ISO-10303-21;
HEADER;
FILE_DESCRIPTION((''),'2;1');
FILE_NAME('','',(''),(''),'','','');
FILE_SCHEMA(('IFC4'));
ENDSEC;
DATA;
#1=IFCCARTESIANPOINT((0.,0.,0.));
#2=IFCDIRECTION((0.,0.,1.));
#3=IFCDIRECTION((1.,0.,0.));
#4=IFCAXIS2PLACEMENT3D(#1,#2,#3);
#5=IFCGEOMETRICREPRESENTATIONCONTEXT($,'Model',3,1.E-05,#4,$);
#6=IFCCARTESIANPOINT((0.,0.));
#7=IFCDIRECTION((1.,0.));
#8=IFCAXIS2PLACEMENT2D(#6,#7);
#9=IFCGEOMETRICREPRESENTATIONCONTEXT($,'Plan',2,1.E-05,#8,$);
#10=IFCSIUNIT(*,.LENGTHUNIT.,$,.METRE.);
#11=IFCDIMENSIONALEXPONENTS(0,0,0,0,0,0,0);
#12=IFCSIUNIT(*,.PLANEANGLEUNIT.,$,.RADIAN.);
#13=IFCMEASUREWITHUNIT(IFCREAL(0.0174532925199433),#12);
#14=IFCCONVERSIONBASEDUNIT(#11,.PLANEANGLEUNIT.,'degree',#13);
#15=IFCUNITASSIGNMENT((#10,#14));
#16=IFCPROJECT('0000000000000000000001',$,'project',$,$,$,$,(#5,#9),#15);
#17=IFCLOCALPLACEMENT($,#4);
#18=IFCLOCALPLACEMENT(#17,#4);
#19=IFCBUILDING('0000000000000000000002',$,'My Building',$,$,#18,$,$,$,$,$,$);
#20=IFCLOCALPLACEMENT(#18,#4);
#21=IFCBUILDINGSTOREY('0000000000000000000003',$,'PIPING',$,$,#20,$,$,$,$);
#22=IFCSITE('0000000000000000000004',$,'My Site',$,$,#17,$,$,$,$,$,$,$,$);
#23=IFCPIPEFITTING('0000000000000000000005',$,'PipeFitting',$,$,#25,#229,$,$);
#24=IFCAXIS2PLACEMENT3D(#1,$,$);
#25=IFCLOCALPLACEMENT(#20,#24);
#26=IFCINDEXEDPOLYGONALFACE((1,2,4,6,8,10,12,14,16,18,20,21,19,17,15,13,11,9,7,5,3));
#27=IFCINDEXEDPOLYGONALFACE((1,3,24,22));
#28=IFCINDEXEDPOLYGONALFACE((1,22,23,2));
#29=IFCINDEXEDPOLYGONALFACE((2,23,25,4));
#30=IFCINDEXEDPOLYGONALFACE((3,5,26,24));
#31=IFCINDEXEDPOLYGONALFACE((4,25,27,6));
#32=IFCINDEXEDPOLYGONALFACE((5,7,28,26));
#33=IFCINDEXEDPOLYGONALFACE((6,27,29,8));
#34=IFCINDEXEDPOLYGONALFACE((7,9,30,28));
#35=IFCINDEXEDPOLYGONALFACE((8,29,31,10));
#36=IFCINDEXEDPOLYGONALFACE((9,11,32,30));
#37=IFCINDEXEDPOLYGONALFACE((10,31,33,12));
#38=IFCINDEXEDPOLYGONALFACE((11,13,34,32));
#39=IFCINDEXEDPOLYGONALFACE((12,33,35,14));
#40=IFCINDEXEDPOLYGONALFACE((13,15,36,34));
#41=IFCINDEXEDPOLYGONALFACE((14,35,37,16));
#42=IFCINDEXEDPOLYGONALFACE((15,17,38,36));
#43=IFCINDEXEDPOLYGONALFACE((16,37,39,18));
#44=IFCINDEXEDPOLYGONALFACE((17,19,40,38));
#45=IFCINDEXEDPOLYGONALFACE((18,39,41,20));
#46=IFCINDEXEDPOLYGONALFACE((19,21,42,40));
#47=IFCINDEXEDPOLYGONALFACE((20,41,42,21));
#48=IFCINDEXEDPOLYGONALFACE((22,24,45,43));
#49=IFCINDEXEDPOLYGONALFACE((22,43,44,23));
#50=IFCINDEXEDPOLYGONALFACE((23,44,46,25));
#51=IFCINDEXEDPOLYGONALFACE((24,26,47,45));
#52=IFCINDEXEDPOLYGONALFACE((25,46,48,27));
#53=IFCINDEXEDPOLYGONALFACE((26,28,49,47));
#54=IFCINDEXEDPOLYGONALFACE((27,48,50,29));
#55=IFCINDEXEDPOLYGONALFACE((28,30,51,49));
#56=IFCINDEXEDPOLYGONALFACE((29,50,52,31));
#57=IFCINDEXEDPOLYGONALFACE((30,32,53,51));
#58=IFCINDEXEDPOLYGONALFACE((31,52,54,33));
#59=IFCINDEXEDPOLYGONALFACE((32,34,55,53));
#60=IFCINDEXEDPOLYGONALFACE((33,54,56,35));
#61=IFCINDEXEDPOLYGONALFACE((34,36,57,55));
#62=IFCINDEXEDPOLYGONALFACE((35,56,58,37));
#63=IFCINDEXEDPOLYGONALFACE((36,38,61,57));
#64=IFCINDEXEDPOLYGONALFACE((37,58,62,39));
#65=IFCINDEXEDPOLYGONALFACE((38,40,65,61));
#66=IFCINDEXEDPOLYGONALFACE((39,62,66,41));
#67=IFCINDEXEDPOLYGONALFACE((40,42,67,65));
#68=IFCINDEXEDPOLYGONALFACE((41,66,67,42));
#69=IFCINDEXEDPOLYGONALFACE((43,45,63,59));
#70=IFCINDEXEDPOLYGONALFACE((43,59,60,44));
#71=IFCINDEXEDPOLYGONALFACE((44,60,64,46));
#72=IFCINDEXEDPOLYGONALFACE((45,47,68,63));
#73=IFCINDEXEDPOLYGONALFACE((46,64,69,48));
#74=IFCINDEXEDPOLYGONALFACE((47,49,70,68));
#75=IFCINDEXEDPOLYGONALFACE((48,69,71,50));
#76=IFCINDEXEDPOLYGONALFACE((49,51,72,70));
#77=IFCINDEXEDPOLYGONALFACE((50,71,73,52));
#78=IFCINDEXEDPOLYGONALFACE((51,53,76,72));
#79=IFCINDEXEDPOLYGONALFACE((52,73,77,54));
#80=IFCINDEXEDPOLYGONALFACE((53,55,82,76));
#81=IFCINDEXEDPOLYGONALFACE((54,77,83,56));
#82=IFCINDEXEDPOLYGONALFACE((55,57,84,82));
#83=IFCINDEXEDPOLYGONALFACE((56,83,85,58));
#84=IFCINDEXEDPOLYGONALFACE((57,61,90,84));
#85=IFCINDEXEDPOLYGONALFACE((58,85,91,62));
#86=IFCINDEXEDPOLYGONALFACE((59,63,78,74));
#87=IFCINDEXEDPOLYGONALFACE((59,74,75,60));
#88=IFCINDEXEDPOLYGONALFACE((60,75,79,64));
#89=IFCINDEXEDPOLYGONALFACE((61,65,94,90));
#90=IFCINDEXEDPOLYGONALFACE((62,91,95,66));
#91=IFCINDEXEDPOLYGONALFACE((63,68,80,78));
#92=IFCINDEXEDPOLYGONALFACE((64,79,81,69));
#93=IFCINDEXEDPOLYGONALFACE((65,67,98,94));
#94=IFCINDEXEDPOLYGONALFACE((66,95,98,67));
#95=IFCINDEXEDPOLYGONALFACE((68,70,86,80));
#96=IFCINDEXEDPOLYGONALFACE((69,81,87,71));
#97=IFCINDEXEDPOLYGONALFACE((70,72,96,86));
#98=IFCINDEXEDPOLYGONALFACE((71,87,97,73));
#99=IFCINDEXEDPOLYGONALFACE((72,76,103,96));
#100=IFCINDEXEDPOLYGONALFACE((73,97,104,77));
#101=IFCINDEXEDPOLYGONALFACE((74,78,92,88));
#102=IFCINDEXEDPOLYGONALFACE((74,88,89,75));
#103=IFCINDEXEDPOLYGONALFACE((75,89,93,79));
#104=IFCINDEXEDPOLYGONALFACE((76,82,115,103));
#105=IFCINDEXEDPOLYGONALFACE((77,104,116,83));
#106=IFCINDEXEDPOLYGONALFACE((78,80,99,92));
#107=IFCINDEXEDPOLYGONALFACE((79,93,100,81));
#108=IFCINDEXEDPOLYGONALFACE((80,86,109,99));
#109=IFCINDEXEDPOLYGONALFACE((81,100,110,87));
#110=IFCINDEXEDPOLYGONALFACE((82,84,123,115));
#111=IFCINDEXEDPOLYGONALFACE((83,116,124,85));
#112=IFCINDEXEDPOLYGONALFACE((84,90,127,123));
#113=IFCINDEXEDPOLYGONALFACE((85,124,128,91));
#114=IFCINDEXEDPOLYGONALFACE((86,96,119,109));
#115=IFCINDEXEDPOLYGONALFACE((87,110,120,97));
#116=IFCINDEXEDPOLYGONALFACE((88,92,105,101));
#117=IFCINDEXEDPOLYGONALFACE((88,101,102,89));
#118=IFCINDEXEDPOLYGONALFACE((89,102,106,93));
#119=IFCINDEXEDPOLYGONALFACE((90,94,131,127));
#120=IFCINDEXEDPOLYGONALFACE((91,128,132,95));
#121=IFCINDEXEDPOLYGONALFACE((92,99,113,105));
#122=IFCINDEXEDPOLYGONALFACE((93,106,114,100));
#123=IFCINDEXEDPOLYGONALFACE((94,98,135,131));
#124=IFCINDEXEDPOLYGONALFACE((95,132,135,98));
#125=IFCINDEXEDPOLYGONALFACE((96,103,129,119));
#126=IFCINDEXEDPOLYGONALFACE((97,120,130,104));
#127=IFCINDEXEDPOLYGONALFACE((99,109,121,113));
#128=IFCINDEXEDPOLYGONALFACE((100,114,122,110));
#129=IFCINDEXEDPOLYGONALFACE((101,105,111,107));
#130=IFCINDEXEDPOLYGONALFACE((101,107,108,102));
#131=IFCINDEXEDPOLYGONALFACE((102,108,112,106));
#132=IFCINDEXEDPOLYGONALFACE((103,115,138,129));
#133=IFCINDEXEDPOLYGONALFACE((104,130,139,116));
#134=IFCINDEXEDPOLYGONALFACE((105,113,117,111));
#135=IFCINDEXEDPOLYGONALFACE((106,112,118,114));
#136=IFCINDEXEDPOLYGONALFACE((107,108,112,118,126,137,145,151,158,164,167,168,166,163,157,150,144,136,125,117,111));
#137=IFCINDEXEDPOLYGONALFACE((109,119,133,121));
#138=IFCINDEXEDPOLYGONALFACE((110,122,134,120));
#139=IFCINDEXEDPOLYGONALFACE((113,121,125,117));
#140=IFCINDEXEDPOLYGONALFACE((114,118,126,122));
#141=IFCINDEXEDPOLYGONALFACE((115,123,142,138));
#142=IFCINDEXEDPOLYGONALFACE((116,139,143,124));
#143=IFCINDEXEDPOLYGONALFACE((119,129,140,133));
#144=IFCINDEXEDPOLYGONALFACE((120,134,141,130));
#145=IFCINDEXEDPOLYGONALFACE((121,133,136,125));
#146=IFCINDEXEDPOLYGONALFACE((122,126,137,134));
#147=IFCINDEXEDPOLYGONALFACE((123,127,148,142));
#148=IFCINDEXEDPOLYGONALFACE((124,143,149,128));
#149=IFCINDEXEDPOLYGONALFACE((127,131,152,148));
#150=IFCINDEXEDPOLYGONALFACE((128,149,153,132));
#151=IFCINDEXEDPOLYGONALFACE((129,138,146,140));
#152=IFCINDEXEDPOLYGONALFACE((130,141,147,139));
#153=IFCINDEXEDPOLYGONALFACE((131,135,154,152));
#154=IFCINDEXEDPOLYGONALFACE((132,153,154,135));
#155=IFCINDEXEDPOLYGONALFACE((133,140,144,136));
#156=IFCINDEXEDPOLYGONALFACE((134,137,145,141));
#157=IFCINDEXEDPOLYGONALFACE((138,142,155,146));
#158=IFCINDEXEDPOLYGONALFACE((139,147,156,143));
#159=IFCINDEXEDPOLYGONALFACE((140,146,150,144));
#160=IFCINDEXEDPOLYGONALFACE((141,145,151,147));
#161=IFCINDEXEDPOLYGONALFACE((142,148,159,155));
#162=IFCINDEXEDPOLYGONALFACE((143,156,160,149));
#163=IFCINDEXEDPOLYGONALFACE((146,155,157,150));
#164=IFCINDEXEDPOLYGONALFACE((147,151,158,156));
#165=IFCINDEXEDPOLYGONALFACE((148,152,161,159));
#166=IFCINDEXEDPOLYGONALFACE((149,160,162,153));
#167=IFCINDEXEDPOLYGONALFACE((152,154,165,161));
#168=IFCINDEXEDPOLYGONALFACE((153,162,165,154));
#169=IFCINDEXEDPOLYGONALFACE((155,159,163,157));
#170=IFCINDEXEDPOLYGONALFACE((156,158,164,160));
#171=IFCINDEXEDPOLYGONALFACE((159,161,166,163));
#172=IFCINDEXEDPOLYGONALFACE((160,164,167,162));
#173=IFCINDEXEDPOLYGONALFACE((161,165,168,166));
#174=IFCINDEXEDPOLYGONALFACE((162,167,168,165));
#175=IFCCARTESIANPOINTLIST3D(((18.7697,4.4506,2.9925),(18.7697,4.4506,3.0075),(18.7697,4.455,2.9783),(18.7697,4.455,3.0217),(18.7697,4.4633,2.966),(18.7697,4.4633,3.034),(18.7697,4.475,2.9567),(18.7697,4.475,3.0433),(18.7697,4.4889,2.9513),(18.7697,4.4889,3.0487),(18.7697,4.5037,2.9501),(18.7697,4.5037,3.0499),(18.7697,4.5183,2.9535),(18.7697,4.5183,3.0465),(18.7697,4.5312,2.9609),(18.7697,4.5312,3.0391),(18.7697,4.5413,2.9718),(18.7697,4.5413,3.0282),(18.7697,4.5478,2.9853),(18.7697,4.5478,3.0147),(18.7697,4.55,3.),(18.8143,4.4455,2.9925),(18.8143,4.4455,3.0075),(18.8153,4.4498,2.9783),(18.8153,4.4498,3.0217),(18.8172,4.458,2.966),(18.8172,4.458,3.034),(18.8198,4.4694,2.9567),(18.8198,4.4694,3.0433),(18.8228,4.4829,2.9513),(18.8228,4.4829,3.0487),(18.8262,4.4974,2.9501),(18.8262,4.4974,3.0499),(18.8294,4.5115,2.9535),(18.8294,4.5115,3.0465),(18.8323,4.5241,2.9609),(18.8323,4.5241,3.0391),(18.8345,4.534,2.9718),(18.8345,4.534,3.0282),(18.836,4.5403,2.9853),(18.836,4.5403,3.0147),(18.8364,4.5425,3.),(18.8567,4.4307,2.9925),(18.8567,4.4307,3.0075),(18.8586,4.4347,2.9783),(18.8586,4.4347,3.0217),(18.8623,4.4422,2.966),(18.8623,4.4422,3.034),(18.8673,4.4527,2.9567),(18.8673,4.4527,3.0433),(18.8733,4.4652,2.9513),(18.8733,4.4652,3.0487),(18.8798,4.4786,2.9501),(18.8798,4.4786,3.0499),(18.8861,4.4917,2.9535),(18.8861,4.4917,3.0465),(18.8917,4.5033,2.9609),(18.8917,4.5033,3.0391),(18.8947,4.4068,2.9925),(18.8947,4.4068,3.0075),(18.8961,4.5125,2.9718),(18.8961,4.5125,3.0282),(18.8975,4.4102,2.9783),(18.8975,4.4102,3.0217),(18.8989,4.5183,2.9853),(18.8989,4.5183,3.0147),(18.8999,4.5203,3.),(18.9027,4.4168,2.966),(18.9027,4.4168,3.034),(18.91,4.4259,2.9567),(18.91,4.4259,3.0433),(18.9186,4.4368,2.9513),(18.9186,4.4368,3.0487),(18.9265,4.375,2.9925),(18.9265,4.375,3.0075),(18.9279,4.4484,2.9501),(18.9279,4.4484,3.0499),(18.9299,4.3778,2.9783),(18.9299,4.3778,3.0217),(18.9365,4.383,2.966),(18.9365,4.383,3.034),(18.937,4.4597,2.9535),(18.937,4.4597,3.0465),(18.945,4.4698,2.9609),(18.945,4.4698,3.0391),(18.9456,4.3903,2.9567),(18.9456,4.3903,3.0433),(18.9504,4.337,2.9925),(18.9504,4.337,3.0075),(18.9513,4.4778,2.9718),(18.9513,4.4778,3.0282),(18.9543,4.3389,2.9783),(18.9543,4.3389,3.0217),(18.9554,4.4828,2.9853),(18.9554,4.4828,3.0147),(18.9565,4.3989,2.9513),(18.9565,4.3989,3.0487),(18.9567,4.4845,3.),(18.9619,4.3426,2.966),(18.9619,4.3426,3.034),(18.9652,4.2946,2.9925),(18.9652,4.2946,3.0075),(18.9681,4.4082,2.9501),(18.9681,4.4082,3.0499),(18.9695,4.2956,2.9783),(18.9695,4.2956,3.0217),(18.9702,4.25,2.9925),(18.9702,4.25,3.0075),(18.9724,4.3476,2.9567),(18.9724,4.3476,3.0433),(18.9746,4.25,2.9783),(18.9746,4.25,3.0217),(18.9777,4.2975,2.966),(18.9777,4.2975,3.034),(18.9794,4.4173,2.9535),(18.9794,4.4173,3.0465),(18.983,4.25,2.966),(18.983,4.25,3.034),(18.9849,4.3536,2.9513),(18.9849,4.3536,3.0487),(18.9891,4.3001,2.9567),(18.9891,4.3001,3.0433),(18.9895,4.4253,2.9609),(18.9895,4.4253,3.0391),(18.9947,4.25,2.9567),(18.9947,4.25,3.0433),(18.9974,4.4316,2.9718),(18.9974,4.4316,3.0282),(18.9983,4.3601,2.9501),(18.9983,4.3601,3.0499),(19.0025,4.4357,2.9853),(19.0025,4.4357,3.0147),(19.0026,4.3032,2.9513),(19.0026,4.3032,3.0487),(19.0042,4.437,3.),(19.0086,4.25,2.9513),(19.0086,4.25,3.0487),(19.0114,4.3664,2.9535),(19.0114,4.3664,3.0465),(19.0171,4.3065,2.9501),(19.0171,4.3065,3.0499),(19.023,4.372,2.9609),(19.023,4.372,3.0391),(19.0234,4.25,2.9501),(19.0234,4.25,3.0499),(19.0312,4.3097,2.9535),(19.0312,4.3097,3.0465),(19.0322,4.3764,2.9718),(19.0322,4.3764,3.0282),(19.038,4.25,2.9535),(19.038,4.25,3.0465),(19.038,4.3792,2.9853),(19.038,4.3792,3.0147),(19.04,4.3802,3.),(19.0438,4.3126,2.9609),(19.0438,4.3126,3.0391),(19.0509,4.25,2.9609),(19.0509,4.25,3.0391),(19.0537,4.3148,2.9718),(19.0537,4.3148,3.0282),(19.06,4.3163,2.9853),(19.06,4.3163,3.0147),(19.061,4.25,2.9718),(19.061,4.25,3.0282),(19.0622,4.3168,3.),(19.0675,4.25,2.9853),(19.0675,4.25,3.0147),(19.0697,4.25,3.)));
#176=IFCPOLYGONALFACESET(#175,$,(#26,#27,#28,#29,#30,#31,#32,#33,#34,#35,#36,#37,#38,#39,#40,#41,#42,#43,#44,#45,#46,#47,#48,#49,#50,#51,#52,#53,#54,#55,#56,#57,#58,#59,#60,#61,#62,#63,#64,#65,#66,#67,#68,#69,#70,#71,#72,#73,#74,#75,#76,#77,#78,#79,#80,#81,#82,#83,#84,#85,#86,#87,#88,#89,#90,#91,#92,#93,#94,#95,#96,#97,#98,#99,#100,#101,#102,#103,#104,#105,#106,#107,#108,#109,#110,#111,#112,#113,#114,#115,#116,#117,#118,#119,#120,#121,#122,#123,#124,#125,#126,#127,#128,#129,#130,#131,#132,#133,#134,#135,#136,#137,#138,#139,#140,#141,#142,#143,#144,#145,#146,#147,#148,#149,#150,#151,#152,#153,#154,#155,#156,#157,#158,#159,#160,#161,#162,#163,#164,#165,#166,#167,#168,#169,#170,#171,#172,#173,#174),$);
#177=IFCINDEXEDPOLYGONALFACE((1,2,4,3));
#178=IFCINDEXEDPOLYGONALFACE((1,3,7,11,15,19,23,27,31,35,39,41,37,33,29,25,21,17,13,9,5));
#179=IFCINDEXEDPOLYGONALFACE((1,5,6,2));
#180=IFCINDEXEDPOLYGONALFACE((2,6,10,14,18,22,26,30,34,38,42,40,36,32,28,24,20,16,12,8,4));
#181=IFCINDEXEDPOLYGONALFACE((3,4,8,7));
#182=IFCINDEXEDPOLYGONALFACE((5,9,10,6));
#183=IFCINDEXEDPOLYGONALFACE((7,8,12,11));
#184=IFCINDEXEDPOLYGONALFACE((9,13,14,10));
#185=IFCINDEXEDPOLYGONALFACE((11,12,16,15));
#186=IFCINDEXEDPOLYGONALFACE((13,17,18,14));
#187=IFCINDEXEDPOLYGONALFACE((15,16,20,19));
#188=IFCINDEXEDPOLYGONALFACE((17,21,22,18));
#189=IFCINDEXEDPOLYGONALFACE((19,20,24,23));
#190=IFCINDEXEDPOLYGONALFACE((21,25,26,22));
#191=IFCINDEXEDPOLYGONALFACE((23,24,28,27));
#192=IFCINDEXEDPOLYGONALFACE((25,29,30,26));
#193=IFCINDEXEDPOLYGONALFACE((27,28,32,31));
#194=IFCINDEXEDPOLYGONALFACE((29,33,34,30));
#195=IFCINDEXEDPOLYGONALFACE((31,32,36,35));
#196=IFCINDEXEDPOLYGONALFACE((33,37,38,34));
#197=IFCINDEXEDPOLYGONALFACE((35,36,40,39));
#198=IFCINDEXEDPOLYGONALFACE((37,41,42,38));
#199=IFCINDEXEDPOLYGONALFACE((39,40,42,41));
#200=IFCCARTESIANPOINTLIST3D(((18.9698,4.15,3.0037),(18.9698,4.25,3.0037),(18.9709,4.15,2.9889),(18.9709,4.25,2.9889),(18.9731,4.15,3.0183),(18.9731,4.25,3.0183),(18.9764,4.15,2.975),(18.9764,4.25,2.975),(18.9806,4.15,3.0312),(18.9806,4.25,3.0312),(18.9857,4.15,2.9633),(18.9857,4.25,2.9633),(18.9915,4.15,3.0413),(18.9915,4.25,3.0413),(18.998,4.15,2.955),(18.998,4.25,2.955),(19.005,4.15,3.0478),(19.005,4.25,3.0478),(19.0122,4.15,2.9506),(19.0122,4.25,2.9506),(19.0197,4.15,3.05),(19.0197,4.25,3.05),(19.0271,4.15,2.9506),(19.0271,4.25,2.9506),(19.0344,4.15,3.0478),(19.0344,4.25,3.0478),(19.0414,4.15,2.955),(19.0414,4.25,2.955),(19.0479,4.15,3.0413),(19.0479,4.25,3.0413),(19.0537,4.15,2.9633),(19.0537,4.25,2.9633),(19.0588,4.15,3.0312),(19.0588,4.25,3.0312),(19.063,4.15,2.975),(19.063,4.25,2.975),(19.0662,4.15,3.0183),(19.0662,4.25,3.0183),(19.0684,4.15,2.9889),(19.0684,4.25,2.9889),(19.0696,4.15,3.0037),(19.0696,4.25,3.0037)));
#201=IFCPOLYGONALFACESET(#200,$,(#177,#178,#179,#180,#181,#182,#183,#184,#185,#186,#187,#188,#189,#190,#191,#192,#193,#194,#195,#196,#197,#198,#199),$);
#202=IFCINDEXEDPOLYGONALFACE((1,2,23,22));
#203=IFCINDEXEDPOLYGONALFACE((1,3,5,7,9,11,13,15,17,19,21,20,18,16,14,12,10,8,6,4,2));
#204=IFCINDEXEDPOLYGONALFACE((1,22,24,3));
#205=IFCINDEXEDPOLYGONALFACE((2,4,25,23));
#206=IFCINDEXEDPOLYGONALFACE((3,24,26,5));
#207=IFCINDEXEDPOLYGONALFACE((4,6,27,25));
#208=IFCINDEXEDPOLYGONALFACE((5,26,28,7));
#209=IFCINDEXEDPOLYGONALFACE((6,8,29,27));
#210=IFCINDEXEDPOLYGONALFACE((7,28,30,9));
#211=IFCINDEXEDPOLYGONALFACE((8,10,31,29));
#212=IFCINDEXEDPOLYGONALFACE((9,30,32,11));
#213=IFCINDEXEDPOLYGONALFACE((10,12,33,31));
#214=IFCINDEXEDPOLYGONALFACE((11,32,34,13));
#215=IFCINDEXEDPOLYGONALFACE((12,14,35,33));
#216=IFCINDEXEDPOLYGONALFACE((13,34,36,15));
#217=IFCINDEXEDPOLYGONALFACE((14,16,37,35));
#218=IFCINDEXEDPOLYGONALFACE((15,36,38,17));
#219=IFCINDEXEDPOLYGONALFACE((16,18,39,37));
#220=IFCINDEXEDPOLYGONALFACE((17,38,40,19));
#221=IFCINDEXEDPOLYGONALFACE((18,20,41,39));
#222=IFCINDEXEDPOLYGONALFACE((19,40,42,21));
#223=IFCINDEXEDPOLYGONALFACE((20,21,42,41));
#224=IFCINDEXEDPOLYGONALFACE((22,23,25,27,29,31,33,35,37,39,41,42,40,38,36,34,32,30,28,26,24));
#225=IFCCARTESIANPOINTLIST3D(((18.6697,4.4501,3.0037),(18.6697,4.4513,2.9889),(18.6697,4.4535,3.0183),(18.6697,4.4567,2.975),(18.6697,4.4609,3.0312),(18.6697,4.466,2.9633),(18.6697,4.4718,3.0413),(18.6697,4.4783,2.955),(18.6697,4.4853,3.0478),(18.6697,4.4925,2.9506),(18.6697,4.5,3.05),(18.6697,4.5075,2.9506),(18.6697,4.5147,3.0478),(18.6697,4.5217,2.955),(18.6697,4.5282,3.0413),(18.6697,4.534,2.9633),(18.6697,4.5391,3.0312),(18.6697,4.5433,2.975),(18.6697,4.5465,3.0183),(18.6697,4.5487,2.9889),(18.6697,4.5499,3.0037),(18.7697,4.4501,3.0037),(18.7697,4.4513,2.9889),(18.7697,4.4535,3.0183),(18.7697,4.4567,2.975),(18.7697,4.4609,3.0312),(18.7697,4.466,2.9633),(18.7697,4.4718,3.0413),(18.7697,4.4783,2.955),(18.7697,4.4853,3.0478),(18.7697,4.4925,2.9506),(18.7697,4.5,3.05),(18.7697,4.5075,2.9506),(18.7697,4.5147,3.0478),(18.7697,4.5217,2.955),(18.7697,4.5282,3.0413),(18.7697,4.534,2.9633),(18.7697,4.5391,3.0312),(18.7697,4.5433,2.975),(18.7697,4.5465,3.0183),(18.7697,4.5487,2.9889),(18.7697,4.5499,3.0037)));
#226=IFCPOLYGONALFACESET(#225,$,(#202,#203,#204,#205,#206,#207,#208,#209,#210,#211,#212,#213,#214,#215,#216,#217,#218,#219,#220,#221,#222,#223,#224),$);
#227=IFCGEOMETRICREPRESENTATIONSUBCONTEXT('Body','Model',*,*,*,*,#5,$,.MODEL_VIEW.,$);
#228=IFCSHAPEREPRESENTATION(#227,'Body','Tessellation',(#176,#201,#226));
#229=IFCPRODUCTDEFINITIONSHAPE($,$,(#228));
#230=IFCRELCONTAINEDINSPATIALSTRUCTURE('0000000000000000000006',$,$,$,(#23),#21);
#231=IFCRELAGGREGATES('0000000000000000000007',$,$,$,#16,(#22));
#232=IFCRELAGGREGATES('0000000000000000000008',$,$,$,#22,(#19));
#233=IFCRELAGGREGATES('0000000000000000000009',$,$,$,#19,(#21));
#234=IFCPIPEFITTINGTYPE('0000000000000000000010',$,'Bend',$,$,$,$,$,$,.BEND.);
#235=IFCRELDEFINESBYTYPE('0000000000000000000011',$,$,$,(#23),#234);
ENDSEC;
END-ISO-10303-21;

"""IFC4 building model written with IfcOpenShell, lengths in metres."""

from ifc_helpers import new_model, entity, si_unit, converted_unit, frame, origin_with_axes, origin_2d_with_axis, place, context, subcontext, project, spatial, circle, extrude, source, transform, mapped, type_object, type_shapes, element, save


model = new_model("IFC4")

# Units and contexts
model_context = context("Model", 3, precision=1e-05, world=origin_with_axes())
plan_context = context("Plan", 2, precision=1e-05, world=origin_2d_with_axis())
body_context = subcontext(model_context, "Body", "Model", "MODEL_VIEW")
ifc_project = project(units=[si_unit("LENGTHUNIT", "METRE"), converted_unit("PLANEANGLEUNIT", "degree", entity("IfcReal", 0.0174532925199433), si_unit("PLANEANGLEUNIT", "RADIAN"), dimensions=[0, 0, 0, 0, 0, 0, 0])], contexts=[model_context, plan_context])

# Site, building, storey
site_placement = place(None, origin_with_axes())
site = spatial("IfcSite", under=ifc_project, at=site_placement, Name="My Site")
building_placement = place(site_placement, origin_with_axes())
building = spatial("IfcBuilding", under=site, at=building_placement, Name="My Building")
storey_placement = place(building_placement, origin_with_axes())
storey = spatial("IfcBuildingStorey", under=building, at=storey_placement, Name="PIPING")

# Pipe fitting
pipe_fitting_type_1 = type_object("IfcPipeFittingType", Name="Bend", PredefinedType="BEND")
shared_shape = source(origin_with_axes(), body_context, "Body", "SolidModel", [
    entity("IfcSweptDiskSolid", entity("IfcIndexedPolyCurve", entity("IfcCartesianPointList3D", [[0.0, 0.0, -0.1], [0.0, 0.0732, -0.2768], [0.0, 0.25, -0.35]]), [entity("IfcArcIndex", [1, 2, 3])]), 0.05),
    extrude(circle(Radius=0.05), origin_with_axes(), (0.0, 0.0, -1.0), 0.1),
    extrude(circle(Radius=0.05), frame((0.0, 0.25, -0.35), z_axis=(0.0, 1.0, 0.0), x_axis=(1.0, 0.0, 0.0)), (0.0, 0.0, 1.0), 0.1),
])
type_shapes(pipe_fitting_type_1, [shared_shape])
for number, where, z_axis, x_axis, name in (
    (1, (19.0197, 4.15, 3.0), (0.0, -1.0, 0.0), (0.0, 0.0, 1.0), "PipeFitting"),
):
    element("IfcPipeFitting", number, at=place(storey_placement, frame(where, z_axis=z_axis, x_axis=x_axis)), inside=storey, type_object=pipe_fitting_type_1, Name=name, context=body_context, shape_type="MappedRepresentation", body=[
        mapped(shared_shape, transform((0.0, 0.0, 0.0), x_axis=(1.0, 0.0, 0.0), y_axis=(0.0, 1.0, 0.0), z_axis=(0.0, 0.0, 1.0), scale=1.0)),
    ])

save(model, "model.ifc")
